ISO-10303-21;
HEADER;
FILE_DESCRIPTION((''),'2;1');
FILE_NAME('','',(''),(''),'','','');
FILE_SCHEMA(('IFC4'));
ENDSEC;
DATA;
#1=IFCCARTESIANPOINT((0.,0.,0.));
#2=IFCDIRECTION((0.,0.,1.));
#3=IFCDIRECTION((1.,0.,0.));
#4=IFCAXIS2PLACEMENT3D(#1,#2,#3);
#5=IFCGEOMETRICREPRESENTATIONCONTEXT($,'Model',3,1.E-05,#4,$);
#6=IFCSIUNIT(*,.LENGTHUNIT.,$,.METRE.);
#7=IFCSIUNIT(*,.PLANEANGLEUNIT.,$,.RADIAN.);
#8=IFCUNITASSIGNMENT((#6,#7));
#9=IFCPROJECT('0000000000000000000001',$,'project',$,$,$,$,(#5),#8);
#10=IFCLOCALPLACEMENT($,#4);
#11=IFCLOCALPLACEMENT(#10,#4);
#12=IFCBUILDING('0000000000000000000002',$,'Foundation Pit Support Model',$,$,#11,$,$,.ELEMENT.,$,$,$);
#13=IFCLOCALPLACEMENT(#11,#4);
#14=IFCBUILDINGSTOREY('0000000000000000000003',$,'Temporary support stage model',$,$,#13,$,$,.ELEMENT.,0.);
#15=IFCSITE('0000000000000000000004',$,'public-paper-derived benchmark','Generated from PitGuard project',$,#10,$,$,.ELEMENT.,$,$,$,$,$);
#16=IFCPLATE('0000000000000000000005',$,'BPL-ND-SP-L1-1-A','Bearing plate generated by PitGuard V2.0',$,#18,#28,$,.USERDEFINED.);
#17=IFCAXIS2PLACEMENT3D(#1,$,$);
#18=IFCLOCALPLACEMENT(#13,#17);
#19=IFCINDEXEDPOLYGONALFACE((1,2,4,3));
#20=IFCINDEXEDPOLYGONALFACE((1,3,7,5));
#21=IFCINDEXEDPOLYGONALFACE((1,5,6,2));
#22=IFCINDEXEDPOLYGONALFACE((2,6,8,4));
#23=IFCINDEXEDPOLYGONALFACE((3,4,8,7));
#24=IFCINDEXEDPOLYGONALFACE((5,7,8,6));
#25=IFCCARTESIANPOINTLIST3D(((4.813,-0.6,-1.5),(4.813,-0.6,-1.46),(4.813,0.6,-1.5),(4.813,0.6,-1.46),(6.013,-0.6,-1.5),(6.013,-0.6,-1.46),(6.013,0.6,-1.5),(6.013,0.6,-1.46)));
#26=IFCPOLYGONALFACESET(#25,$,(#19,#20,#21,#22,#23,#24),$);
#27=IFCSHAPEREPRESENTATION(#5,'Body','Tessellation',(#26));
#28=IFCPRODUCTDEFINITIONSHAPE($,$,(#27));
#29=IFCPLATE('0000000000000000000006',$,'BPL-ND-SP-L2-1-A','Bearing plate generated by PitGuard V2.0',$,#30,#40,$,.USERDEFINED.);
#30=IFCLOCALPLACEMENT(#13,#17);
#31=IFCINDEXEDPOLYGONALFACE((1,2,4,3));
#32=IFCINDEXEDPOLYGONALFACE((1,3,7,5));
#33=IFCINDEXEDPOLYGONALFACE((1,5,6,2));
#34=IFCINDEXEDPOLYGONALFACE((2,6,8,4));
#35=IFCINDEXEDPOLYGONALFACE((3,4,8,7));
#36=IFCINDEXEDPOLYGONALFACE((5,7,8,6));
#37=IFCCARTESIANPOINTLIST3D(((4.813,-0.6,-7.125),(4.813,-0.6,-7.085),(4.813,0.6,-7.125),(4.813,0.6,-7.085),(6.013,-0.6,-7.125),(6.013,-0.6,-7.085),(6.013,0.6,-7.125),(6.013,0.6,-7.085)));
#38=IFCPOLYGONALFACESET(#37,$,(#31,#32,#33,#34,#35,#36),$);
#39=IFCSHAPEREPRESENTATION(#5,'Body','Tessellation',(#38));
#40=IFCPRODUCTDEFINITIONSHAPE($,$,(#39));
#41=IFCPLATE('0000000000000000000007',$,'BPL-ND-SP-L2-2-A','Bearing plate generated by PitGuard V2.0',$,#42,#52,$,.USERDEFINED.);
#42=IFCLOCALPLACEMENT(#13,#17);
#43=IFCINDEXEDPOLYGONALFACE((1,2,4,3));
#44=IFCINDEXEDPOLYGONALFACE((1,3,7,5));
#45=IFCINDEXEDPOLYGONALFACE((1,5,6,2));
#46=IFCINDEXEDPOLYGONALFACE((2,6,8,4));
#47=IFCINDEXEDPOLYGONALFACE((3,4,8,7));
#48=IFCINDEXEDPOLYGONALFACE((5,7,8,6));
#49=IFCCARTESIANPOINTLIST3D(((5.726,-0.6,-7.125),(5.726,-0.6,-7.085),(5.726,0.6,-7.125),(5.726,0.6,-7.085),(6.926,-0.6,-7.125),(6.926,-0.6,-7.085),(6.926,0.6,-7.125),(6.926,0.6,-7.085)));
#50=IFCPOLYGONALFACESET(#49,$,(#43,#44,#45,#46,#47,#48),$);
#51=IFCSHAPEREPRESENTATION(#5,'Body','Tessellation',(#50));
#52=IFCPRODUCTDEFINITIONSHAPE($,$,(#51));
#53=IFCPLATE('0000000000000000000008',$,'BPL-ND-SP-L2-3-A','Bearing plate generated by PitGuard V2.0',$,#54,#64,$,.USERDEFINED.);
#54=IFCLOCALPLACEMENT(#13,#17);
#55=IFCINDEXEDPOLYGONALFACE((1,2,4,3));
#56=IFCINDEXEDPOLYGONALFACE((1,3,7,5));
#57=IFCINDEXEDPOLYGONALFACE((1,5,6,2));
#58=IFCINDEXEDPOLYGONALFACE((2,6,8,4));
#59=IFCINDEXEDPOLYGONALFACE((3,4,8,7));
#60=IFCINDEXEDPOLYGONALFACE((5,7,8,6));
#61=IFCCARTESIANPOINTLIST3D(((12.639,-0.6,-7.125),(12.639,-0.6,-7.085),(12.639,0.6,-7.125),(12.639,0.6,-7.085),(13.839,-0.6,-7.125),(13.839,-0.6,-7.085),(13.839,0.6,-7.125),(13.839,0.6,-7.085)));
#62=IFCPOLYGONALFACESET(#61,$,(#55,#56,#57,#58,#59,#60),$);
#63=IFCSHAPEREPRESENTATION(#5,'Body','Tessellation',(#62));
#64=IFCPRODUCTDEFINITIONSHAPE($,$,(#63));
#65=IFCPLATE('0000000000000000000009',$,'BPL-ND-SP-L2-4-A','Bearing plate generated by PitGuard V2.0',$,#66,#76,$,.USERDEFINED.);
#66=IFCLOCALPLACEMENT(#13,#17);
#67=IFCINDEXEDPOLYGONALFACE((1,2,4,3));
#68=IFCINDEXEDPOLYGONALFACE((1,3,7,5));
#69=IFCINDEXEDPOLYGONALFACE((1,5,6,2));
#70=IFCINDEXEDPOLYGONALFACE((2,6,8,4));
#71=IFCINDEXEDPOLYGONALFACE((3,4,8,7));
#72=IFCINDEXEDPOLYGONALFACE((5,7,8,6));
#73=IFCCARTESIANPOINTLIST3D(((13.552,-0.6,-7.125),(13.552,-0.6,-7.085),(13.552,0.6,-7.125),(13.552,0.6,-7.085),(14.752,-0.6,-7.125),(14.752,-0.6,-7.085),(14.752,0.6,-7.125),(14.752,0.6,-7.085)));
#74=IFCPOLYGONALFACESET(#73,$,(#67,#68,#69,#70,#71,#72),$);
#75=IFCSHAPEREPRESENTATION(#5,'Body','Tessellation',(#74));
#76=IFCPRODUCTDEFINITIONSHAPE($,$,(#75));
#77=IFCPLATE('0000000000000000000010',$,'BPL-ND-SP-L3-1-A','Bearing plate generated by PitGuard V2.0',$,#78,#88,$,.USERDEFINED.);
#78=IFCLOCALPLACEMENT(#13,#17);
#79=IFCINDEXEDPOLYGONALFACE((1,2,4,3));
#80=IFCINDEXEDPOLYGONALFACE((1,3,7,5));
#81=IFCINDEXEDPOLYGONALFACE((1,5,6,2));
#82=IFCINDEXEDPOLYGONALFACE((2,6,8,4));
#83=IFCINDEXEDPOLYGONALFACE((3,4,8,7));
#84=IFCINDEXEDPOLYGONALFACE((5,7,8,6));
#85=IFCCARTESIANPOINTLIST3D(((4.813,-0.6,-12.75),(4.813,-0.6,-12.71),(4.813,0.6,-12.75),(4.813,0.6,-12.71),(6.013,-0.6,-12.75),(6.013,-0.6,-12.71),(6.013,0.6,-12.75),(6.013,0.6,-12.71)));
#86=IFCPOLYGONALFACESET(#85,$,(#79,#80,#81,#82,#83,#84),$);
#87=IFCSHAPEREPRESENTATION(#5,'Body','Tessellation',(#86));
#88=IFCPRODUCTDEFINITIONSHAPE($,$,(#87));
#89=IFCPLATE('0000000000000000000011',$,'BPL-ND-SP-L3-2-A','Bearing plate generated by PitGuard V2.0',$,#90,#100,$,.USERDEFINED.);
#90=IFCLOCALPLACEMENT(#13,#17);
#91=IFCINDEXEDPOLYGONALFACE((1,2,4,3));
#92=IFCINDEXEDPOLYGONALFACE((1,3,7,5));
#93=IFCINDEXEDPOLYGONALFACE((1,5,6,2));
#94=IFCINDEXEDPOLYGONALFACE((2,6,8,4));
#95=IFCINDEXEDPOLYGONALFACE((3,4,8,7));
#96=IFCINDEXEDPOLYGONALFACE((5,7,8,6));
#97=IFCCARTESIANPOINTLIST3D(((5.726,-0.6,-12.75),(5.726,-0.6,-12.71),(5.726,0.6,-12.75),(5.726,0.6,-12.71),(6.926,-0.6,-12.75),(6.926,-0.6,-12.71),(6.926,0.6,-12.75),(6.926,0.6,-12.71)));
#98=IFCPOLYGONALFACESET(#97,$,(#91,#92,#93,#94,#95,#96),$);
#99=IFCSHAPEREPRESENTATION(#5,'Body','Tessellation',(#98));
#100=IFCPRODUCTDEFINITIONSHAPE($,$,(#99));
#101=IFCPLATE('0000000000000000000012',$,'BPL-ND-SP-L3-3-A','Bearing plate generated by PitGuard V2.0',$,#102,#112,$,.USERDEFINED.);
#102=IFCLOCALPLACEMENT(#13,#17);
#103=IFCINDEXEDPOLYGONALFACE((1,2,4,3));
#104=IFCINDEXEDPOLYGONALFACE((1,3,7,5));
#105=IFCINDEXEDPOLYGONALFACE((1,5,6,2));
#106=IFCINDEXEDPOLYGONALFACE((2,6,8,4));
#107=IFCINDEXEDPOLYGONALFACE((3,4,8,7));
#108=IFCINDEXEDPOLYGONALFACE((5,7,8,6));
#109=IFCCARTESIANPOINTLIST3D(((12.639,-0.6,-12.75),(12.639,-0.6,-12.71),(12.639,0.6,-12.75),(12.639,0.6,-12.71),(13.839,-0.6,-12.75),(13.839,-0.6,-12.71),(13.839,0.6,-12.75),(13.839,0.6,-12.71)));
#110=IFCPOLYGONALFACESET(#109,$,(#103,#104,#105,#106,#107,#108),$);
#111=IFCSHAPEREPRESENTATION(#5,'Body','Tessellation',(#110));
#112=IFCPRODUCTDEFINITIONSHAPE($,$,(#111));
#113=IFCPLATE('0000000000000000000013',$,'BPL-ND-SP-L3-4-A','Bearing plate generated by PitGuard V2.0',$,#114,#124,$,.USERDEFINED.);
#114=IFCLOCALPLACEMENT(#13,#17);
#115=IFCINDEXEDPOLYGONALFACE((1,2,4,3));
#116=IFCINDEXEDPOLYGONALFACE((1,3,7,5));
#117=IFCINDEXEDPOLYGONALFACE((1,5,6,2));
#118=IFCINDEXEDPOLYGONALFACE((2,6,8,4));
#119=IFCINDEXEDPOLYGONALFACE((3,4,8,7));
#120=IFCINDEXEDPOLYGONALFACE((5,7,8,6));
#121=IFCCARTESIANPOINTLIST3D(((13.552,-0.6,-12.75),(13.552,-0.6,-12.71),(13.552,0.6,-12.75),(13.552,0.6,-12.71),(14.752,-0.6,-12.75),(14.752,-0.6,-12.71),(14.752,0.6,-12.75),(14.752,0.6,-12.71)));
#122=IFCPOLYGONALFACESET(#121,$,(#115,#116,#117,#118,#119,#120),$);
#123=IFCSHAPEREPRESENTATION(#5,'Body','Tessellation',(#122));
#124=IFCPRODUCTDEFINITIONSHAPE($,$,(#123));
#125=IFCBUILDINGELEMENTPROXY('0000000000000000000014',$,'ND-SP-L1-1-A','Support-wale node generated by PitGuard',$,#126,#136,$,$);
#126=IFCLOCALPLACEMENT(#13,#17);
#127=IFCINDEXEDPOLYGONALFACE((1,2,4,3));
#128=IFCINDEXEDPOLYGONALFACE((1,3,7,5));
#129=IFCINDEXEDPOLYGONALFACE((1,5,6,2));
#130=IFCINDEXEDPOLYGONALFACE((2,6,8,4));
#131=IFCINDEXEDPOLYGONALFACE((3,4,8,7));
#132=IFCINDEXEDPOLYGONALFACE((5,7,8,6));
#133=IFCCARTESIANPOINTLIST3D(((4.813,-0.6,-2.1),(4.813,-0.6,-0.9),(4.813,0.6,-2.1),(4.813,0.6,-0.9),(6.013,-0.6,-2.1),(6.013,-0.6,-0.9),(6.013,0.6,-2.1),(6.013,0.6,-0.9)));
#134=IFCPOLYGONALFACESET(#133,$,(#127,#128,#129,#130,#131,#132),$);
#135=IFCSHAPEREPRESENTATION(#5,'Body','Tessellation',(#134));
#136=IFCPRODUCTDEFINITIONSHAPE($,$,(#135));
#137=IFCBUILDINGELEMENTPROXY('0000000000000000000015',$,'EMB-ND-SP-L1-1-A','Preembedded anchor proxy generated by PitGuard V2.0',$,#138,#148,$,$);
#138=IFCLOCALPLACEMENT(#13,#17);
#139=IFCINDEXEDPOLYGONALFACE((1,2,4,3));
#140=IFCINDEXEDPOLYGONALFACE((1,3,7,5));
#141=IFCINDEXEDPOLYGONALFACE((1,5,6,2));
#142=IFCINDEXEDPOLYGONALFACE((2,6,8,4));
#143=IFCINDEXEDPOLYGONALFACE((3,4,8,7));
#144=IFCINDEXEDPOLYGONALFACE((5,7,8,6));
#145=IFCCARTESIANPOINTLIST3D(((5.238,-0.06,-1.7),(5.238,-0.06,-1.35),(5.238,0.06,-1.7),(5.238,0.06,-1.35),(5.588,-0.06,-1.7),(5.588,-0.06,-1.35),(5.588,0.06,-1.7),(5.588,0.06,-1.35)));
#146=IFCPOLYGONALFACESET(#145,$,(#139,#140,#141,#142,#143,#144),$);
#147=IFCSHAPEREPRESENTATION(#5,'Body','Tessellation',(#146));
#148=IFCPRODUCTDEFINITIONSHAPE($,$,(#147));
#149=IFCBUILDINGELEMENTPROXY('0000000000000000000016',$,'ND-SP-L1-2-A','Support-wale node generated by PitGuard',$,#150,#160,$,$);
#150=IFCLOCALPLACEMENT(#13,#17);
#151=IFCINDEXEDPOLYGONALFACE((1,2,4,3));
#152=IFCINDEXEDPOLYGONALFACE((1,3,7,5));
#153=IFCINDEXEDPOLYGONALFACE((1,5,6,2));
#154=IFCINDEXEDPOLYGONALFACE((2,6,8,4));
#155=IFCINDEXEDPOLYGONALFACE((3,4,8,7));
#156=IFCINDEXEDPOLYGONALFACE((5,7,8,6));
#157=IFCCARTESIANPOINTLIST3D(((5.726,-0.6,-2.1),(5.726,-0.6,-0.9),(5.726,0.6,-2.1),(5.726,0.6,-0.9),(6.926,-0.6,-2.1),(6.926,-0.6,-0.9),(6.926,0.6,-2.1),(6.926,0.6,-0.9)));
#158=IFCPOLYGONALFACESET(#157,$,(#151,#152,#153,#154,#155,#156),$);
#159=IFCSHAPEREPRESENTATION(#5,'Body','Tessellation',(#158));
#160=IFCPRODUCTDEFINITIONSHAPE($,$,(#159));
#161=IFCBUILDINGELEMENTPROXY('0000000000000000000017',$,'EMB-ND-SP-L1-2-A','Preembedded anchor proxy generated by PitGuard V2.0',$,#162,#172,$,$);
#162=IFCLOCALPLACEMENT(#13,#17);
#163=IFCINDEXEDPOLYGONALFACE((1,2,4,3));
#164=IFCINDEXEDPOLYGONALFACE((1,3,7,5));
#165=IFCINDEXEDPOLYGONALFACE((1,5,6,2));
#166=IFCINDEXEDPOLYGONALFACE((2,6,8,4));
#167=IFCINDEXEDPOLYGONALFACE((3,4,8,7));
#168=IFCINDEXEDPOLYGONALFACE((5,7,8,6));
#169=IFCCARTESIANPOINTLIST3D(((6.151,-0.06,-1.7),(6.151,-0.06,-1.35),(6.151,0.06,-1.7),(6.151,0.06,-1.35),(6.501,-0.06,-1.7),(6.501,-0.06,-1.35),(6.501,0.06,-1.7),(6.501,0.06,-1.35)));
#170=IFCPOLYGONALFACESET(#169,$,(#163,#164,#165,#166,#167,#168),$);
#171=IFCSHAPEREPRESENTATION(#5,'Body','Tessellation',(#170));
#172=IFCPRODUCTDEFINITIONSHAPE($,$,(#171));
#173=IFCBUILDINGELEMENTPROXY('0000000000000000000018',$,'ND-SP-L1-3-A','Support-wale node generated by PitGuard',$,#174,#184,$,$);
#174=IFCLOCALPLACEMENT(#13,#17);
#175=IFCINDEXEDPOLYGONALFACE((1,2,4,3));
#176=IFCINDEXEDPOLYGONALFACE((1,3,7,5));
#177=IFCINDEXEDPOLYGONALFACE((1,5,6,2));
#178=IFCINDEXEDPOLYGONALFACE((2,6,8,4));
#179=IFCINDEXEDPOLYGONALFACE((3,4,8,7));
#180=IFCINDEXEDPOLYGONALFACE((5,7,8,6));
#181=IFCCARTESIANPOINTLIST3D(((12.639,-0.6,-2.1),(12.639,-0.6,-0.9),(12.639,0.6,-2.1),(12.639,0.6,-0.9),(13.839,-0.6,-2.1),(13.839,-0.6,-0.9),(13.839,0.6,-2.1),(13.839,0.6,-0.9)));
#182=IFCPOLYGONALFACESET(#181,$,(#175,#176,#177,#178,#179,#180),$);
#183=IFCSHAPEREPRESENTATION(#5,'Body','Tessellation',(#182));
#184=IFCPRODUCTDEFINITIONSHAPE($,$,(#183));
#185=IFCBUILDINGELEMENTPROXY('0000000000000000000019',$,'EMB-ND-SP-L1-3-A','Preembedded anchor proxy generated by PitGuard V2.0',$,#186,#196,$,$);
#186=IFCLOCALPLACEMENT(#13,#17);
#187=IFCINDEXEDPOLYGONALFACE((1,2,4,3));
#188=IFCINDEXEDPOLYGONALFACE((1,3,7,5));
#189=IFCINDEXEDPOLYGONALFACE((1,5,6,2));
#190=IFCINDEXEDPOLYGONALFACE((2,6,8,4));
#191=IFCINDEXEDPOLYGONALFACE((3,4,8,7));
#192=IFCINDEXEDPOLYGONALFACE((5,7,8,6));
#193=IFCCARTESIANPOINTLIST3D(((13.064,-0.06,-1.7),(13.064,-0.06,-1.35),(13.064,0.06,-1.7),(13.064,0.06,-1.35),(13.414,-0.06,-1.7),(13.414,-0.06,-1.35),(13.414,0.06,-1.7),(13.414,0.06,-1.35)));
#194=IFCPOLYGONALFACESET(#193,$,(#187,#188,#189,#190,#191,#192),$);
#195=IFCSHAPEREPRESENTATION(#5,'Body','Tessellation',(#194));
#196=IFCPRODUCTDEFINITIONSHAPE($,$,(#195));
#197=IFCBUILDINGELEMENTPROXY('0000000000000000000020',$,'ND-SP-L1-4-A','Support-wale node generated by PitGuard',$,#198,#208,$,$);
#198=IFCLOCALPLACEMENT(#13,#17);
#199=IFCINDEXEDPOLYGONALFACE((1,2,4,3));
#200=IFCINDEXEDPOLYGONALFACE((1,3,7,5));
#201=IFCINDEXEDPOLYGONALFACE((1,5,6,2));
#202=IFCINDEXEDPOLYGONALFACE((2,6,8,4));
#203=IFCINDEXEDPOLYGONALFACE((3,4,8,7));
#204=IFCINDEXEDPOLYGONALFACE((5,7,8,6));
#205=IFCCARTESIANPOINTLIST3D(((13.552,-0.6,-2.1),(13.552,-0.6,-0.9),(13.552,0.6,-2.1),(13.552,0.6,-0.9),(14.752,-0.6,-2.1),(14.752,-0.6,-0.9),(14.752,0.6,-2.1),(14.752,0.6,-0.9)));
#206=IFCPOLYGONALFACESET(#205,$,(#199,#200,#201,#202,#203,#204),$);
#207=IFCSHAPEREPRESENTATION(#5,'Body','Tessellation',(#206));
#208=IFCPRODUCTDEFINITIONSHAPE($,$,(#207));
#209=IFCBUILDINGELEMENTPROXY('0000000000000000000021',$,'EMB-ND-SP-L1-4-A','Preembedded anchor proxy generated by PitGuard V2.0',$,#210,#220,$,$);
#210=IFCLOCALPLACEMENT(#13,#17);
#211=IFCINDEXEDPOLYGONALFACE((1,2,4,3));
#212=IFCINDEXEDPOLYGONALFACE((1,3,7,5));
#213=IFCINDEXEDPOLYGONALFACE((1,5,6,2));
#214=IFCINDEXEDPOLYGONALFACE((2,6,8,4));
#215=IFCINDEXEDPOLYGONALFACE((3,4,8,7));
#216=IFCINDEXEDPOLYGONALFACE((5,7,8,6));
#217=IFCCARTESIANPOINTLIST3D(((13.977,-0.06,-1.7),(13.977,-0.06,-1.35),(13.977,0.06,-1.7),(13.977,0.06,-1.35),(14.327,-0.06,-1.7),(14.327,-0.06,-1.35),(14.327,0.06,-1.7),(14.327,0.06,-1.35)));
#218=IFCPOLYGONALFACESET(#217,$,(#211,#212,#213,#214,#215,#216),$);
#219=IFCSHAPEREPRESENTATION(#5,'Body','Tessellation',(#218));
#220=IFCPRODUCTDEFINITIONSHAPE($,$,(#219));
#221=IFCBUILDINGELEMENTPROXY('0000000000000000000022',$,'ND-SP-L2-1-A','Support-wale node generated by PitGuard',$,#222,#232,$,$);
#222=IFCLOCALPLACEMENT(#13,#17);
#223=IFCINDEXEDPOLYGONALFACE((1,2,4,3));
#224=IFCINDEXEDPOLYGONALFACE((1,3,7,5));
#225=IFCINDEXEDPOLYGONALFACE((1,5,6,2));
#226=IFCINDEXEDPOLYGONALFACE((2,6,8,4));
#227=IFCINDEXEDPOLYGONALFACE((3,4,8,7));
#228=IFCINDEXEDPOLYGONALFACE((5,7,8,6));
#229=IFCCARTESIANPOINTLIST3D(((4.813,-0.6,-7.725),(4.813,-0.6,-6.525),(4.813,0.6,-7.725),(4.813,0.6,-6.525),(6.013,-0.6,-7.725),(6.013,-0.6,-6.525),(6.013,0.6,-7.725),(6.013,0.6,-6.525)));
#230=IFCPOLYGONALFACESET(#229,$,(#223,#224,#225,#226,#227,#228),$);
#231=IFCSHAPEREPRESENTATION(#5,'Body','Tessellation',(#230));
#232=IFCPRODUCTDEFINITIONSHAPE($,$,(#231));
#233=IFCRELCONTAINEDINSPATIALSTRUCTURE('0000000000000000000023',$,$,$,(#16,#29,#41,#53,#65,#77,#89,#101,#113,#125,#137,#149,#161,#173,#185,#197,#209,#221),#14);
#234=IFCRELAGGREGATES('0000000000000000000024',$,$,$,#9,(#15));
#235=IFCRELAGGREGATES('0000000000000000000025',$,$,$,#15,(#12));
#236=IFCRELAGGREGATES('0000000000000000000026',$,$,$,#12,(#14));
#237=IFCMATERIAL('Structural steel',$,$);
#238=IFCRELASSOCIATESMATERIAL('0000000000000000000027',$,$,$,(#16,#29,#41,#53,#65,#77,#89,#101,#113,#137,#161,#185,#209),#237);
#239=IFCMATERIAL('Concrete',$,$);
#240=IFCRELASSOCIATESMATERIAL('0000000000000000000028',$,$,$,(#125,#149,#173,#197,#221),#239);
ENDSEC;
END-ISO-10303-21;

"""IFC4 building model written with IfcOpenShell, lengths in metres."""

from ifc_helpers import new_model, si_unit, frame, origin_with_axes, origin_2d, place, context, project, spatial, rectangle, extrude, material, element, save


model = new_model("IFC4")

# Units and contexts
model_context = context("Model", 3, precision=1e-05, world=origin_with_axes())
ifc_project = project(units=[si_unit("LENGTHUNIT", "METRE"), si_unit("PLANEANGLEUNIT", "RADIAN")], contexts=[model_context])

# Site, building, storey
site_placement = place(None, origin_with_axes())
site = spatial("IfcSite", under=ifc_project, at=site_placement, Name="public-paper-derived benchmark", Description="Generated from PitGuard project", CompositionType="ELEMENT")
building_placement = place(site_placement, origin_with_axes())
building = spatial("IfcBuilding", under=site, at=building_placement, Name="Foundation Pit Support Model", CompositionType="ELEMENT")
storey_placement = place(building_placement, origin_with_axes())
storey = spatial("IfcBuildingStorey", under=building, at=storey_placement, Name="Temporary support stage model", CompositionType="ELEMENT", Elevation=0.0)

# Plates
ifc_material_1 = material(Name="Structural steel")
for number, where, z_axis, x_axis, name in (
    (1, (5.413, 0.0, -1.5), (0.0, 0.0, 1.0), (1.0, 0.0, 0.0), "BPL-ND-SP-L1-1-A"),
    (2, (5.413, 0.0, -7.125), (0.0, 0.0, 1.0), (1.0, 0.0, 0.0), "BPL-ND-SP-L2-1-A"),
    (3, (6.326, 0.0, -7.125), (0.0, 0.0, 1.0), (1.0, 0.0, 0.0), "BPL-ND-SP-L2-2-A"),
    (4, (13.239, 0.0, -7.125), (0.0, 0.0, 1.0), (1.0, 0.0, 0.0), "BPL-ND-SP-L2-3-A"),
    (5, (14.152, 0.0, -7.125), (0.0, 0.0, 1.0), (1.0, 0.0, 0.0), "BPL-ND-SP-L2-4-A"),
    (6, (5.413, 0.0, -12.75), (0.0, 0.0, 1.0), (1.0, 0.0, 0.0), "BPL-ND-SP-L3-1-A"),
    (7, (6.326, 0.0, -12.75), (0.0, 0.0, 1.0), (1.0, 0.0, 0.0), "BPL-ND-SP-L3-2-A"),
    (8, (13.239, 0.0, -12.75), (0.0, 0.0, 1.0), (1.0, 0.0, 0.0), "BPL-ND-SP-L3-3-A"),
    (9, (14.152, 0.0, -12.75), (0.0, 0.0, 1.0), (1.0, 0.0, 0.0), "BPL-ND-SP-L3-4-A"),
):
    element("IfcPlate", number, at=place(storey_placement, frame(where, z_axis=z_axis, x_axis=x_axis)), inside=storey, material=ifc_material_1, Name=name, Description="Bearing plate generated by PitGuard V2.0", PredefinedType="USERDEFINED", context=model_context, shape_type="SweptSolid", body=[
        extrude(rectangle(XDim=1.2, YDim=1.2, at=origin_2d()), origin_with_axes(), (0.0, 0.0, 1.0), 0.04),
    ])

# Building element proxies
ifc_material_2 = material(Name="Concrete")
proxy_1_placement = place(storey_placement, frame((5.413, 0.0, -2.1), z_axis=(0.0, 0.0, 1.0), x_axis=(1.0, 0.0, 0.0)))
element("IfcBuildingElementProxy", 10, at=proxy_1_placement, inside=storey, material=ifc_material_2, Name="ND-SP-L1-1-A", Description="Support-wale node generated by PitGuard", context=model_context, shape_type="SweptSolid", body=[
    extrude(rectangle(XDim=1.2, YDim=1.2, at=origin_2d()), origin_with_axes(), (0.0, 0.0, 1.0), 1.2),
])
proxy_2_placement = place(storey_placement, frame((5.413, 0.0, -1.7), z_axis=(0.0, 0.0, 1.0), x_axis=(1.0, 0.0, 0.0)))
element("IfcBuildingElementProxy", 11, at=proxy_2_placement, inside=storey, material=ifc_material_1, Name="EMB-ND-SP-L1-1-A", Description="Preembedded anchor proxy generated by PitGuard V2.0", context=model_context, shape_type="SweptSolid", body=[
    extrude(rectangle(XDim=0.35, YDim=0.12, at=origin_2d()), origin_with_axes(), (0.0, 0.0, 1.0), 0.35),
])
proxy_3_placement = place(storey_placement, frame((6.326, 0.0, -2.1), z_axis=(0.0, 0.0, 1.0), x_axis=(1.0, 0.0, 0.0)))
element("IfcBuildingElementProxy", 12, at=proxy_3_placement, inside=storey, material=ifc_material_2, Name="ND-SP-L1-2-A", Description="Support-wale node generated by PitGuard", context=model_context, shape_type="SweptSolid", body=[
    extrude(rectangle(XDim=1.2, YDim=1.2, at=origin_2d()), origin_with_axes(), (0.0, 0.0, 1.0), 1.2),
])
proxy_4_placement = place(storey_placement, frame((6.326, 0.0, -1.7), z_axis=(0.0, 0.0, 1.0), x_axis=(1.0, 0.0, 0.0)))
element("IfcBuildingElementProxy", 13, at=proxy_4_placement, inside=storey, material=ifc_material_1, Name="EMB-ND-SP-L1-2-A", Description="Preembedded anchor proxy generated by PitGuard V2.0", context=model_context, shape_type="SweptSolid", body=[
    extrude(rectangle(XDim=0.35, YDim=0.12, at=origin_2d()), origin_with_axes(), (0.0, 0.0, 1.0), 0.35),
])
proxy_5_placement = place(storey_placement, frame((13.239, 0.0, -2.1), z_axis=(0.0, 0.0, 1.0), x_axis=(1.0, 0.0, 0.0)))
element("IfcBuildingElementProxy", 14, at=proxy_5_placement, inside=storey, material=ifc_material_2, Name="ND-SP-L1-3-A", Description="Support-wale node generated by PitGuard", context=model_context, shape_type="SweptSolid", body=[
    extrude(rectangle(XDim=1.2, YDim=1.2, at=origin_2d()), origin_with_axes(), (0.0, 0.0, 1.0), 1.2),
])
proxy_6_placement = place(storey_placement, frame((13.239, 0.0, -1.7), z_axis=(0.0, 0.0, 1.0), x_axis=(1.0, 0.0, 0.0)))
element("IfcBuildingElementProxy", 15, at=proxy_6_placement, inside=storey, material=ifc_material_1, Name="EMB-ND-SP-L1-3-A", Description="Preembedded anchor proxy generated by PitGuard V2.0", context=model_context, shape_type="SweptSolid", body=[
    extrude(rectangle(XDim=0.35, YDim=0.12, at=origin_2d()), origin_with_axes(), (0.0, 0.0, 1.0), 0.35),
])
proxy_7_placement = place(storey_placement, frame((14.152, 0.0, -2.1), z_axis=(0.0, 0.0, 1.0), x_axis=(1.0, 0.0, 0.0)))
element("IfcBuildingElementProxy", 16, at=proxy_7_placement, inside=storey, material=ifc_material_2, Name="ND-SP-L1-4-A", Description="Support-wale node generated by PitGuard", context=model_context, shape_type="SweptSolid", body=[
    extrude(rectangle(XDim=1.2, YDim=1.2, at=origin_2d()), origin_with_axes(), (0.0, 0.0, 1.0), 1.2),
])
proxy_8_placement = place(storey_placement, frame((14.152, 0.0, -1.7), z_axis=(0.0, 0.0, 1.0), x_axis=(1.0, 0.0, 0.0)))
element("IfcBuildingElementProxy", 17, at=proxy_8_placement, inside=storey, material=ifc_material_1, Name="EMB-ND-SP-L1-4-A", Description="Preembedded anchor proxy generated by PitGuard V2.0", context=model_context, shape_type="SweptSolid", body=[
    extrude(rectangle(XDim=0.35, YDim=0.12, at=origin_2d()), origin_with_axes(), (0.0, 0.0, 1.0), 0.35),
])
proxy_9_placement = place(storey_placement, frame((5.413, 0.0, -7.725), z_axis=(0.0, 0.0, 1.0), x_axis=(1.0, 0.0, 0.0)))
element("IfcBuildingElementProxy", 18, at=proxy_9_placement, inside=storey, material=ifc_material_2, Name="ND-SP-L2-1-A", Description="Support-wale node generated by PitGuard", context=model_context, shape_type="SweptSolid", body=[
    extrude(rectangle(XDim=1.2, YDim=1.2, at=origin_2d()), origin_with_axes(), (0.0, 0.0, 1.0), 1.2),
])

save(model, "model.ifc")
